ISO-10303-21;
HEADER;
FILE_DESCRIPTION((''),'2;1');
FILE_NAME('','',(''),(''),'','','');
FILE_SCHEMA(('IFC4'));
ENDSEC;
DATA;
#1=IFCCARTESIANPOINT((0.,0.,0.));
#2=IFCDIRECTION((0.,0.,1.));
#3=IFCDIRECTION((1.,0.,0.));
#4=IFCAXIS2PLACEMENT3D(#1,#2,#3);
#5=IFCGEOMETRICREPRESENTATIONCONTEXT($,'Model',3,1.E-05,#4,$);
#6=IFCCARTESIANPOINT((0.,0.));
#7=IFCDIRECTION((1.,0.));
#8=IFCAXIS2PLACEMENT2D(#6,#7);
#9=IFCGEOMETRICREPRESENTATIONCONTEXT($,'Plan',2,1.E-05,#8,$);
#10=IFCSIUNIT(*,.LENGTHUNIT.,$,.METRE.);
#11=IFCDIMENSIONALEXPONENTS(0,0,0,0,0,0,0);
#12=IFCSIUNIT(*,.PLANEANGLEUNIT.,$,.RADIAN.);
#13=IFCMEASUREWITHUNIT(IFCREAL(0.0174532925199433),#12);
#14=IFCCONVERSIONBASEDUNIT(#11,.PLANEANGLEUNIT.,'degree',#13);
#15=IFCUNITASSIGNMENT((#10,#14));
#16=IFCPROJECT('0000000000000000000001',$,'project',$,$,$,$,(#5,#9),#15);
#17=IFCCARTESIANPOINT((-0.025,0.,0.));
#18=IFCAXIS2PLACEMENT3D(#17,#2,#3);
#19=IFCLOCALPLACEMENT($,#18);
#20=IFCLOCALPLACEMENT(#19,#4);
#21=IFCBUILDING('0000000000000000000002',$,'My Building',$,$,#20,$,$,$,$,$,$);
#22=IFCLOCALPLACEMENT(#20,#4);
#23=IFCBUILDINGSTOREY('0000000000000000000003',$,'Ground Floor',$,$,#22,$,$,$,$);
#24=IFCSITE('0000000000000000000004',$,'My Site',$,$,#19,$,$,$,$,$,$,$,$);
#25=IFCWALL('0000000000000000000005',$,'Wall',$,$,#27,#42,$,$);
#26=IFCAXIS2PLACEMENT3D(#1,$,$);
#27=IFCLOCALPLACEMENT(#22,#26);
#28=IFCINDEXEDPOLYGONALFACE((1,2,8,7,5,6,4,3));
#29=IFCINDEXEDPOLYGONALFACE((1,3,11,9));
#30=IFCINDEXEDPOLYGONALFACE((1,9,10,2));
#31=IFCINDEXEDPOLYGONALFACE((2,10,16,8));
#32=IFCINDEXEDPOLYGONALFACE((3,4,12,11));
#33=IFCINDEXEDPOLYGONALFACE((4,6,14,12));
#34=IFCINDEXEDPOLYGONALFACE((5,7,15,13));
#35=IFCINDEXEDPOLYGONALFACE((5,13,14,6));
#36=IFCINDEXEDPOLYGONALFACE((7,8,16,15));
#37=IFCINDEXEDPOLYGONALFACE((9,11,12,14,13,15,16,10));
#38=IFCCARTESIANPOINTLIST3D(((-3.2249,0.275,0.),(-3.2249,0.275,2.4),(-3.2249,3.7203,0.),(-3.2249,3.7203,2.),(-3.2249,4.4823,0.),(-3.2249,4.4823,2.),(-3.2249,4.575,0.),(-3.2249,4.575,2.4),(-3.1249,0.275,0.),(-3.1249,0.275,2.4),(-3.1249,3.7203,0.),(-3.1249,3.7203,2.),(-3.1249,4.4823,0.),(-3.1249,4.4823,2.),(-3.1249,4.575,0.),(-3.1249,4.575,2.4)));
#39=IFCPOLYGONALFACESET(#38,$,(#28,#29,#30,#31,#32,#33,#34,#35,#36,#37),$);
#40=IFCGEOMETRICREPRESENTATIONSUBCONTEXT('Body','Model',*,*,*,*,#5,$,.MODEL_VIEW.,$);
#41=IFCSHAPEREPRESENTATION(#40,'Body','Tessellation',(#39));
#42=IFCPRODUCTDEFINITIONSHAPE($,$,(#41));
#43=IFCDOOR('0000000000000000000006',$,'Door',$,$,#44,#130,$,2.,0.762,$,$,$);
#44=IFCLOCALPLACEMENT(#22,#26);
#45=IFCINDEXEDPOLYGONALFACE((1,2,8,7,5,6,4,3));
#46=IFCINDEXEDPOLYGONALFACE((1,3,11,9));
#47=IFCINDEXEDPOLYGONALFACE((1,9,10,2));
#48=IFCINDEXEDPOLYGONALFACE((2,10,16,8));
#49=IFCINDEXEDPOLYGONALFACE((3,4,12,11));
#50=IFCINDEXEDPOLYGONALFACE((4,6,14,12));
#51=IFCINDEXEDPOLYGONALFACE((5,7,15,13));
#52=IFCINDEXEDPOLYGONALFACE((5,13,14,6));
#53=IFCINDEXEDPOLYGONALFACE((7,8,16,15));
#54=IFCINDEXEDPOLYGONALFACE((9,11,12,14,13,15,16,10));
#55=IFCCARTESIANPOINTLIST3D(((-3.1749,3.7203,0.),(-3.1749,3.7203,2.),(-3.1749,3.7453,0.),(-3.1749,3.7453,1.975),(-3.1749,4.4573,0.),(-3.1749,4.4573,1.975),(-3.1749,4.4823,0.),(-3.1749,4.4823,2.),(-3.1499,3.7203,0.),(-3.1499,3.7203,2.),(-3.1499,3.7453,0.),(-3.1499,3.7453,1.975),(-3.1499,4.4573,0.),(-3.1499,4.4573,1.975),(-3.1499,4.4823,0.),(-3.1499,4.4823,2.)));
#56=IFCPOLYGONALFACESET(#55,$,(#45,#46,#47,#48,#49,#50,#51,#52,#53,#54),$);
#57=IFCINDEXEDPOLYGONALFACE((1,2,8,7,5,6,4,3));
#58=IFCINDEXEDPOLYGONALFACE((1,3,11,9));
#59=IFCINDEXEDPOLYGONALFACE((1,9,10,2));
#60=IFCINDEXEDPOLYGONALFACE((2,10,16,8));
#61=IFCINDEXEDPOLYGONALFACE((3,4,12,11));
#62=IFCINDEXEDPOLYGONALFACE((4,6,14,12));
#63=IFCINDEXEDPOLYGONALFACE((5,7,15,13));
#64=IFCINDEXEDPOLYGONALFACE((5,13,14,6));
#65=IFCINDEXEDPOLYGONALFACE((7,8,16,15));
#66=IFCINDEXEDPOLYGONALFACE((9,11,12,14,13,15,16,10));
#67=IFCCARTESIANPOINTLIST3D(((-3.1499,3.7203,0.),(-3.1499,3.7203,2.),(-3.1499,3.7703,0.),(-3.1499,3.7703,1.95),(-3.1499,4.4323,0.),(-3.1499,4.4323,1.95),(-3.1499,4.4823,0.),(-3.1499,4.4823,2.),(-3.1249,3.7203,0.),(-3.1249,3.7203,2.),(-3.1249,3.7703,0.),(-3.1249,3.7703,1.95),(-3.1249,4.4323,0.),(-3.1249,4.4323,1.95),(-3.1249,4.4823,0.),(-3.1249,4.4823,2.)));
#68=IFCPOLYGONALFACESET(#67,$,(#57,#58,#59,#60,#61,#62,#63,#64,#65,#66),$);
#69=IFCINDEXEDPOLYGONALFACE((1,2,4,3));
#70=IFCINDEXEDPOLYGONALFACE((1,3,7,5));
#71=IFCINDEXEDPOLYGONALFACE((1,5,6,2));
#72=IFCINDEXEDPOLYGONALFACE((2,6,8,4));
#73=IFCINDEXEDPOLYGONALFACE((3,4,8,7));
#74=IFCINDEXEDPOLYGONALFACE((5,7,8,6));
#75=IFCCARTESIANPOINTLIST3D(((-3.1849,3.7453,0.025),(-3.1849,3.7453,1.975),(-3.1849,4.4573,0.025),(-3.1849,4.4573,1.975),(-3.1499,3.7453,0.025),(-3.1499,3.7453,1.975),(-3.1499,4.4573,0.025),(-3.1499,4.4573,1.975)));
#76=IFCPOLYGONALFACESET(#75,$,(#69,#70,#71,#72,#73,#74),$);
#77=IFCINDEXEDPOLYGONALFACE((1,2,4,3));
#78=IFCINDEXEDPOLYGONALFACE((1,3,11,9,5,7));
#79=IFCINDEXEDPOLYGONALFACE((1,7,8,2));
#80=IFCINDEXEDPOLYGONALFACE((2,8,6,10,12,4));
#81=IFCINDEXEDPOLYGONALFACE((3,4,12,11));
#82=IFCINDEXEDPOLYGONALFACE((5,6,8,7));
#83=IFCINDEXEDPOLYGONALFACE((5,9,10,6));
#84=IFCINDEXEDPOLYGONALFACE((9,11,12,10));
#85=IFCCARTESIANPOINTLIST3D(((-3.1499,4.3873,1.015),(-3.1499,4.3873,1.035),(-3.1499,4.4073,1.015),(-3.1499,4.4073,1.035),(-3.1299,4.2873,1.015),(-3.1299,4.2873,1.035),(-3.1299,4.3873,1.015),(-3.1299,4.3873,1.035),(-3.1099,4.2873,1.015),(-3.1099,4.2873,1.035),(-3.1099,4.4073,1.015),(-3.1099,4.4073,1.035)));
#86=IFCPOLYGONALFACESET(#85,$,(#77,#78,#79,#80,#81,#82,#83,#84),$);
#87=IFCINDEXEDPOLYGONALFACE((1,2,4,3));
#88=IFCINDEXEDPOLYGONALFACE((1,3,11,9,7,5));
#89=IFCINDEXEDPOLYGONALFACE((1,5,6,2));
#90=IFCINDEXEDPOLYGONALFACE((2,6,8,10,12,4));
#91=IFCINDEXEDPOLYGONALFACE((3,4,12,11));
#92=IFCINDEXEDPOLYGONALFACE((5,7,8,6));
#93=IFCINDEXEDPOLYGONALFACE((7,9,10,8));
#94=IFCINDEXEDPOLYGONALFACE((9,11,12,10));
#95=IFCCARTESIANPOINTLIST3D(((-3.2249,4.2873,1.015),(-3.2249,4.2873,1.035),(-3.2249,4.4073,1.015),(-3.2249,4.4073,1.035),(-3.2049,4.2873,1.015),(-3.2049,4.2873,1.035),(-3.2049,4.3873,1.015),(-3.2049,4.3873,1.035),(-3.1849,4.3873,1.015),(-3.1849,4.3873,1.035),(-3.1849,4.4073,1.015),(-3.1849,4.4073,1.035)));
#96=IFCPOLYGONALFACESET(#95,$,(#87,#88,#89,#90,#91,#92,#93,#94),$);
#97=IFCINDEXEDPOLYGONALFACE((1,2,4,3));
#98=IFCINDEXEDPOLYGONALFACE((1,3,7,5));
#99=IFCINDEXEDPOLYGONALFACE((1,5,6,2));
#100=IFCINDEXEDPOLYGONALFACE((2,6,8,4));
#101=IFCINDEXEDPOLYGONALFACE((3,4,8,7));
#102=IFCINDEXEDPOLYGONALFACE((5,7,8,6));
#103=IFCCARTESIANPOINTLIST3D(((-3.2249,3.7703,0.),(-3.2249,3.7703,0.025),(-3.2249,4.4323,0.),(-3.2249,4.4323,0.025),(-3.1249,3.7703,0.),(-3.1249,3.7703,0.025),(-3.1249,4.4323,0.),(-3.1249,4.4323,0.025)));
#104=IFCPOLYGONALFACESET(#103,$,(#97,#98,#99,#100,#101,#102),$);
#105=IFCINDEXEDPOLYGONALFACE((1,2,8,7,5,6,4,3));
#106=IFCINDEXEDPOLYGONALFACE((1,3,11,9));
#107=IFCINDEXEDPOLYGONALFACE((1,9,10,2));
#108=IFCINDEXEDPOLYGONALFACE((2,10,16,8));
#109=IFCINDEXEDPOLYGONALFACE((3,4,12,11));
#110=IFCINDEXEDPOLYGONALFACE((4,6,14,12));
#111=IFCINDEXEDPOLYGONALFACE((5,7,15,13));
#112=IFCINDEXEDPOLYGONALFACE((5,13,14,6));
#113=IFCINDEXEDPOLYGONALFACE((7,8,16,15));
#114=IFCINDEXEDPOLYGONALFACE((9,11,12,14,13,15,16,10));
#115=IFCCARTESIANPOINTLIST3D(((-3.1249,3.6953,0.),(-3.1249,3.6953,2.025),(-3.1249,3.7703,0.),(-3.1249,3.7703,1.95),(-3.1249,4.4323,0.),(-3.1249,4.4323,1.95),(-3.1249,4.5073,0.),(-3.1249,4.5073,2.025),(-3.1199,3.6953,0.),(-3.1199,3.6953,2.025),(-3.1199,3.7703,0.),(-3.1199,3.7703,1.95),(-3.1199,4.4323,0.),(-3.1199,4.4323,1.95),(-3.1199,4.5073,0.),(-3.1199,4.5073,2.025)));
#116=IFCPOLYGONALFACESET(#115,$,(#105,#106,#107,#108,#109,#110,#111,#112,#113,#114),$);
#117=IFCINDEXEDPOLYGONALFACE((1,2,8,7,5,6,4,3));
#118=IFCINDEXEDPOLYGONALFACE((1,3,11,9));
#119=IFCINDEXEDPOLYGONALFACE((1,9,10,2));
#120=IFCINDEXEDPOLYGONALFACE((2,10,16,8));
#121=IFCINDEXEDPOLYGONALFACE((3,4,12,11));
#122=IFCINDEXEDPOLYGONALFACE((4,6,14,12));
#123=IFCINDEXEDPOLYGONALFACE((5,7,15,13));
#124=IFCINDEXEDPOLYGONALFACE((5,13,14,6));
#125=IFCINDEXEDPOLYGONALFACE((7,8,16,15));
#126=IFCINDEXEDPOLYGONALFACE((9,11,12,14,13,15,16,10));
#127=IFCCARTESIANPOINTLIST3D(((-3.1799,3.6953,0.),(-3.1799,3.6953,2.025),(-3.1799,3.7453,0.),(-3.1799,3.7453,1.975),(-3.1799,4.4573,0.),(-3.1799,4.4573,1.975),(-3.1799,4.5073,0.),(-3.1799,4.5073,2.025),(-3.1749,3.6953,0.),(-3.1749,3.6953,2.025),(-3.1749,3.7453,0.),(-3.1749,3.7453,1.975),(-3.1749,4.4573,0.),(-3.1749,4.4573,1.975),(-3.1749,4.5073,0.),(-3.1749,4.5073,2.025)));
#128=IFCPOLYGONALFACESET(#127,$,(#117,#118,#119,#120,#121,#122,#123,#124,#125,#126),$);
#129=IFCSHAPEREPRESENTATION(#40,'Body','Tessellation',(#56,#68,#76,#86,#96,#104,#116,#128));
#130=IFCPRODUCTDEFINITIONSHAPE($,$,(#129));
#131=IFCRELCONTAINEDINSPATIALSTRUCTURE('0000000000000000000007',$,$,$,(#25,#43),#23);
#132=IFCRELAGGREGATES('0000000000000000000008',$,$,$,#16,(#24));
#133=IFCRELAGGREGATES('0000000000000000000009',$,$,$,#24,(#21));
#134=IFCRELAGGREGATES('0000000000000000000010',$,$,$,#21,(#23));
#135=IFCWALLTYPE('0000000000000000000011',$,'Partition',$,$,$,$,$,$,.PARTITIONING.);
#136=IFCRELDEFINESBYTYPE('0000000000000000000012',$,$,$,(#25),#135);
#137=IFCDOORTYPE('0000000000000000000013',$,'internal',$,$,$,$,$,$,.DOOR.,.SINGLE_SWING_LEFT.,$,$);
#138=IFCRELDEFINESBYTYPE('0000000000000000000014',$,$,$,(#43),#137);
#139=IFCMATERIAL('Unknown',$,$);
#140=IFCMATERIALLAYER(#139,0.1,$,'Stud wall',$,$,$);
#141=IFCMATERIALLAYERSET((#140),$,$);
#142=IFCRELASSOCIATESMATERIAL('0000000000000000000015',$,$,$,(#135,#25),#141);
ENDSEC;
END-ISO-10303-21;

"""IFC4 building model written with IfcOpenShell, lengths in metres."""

from ifc_helpers import new_model, entity, si_unit, converted_unit, frame, origin_with_axes, origin_2d_with_axis, place, context, subcontext, project, spatial, line, indexed_curve, outline, extrude, shape, source, transform, mapped, material, layer, layer_set, layer_usage, type_object, type_shapes, element, fill, save


model = new_model("IFC4")

# Units and contexts
model_context = context("Model", 3, precision=1e-05, world=origin_with_axes())
plan_context = context("Plan", 2, precision=1e-05, world=origin_2d_with_axis())
body_context_1 = subcontext(model_context, "Body", "Model", "MODEL_VIEW")
body_context_2 = subcontext(plan_context, "Body", "Plan", "PLAN_VIEW")
ifc_project = project(units=[si_unit("LENGTHUNIT", "METRE"), converted_unit("PLANEANGLEUNIT", "degree", entity("IfcReal", 0.0174532925199433), si_unit("PLANEANGLEUNIT", "RADIAN"), dimensions=[0, 0, 0, 0, 0, 0, 0])], contexts=[model_context, plan_context])

# Site, building, storey
site_placement = place(None, frame((-0.025, 0.0, 0.0), z_axis=(0.0, 0.0, 1.0), x_axis=(1.0, 0.0, 0.0)))
site = spatial("IfcSite", under=ifc_project, at=site_placement, Name="My Site")
building_placement = place(site_placement, origin_with_axes())
building = spatial("IfcBuilding", under=site, at=building_placement, Name="My Building")
storey_placement = place(building_placement, frame((0.0, 0.0, 0.0), z_axis=(0.0, 0.0, 1.0), x_axis=(1.0, 0.0, 0.0)))
storey = spatial("IfcBuildingStorey", under=building, at=storey_placement, Name="Ground Floor")

# Shared definitions
ifc_material = material(Name="Unknown")
shared_shape_1 = source(origin_with_axes(), body_context_1, "Body", "SweptSolid", [
    extrude(outline(indexed_curve([(0.0, 0.0), (0.762, 0.0), (0.762, 2.0), (0.0, 2.0)], segments=[line(1, 2, 3, 4, 1)])), frame((0.0, -0.6, 0.0), z_axis=(0.0, -1.0, 0.0), x_axis=(1.0, 0.0, 0.0)), (0.0, 0.0, -1.0), 1.2),
])
door_type = type_object("IfcDoorType", Name="internal", OperationType="SINGLE_SWING_LEFT", PredefinedType="DOOR")
shared_shape_2 = source(origin_with_axes(), body_context_1, "Body", "SweptSolid", [
    extrude(outline(indexed_curve([(0.0, 0.0), (0.0, 2.0), (0.762, 2.0), (0.762, 0.0), (0.737, 0.0), (0.737, 1.975), (0.025, 1.975), (0.025, 0.0)], segments=[line(1, 2, 3, 4, 5, 6, 7, 8, 1)])), frame((0.0, 0.025, 0.0), z_axis=(0.0, -1.0, 0.0), x_axis=(1.0, 0.0, 0.0)), (0.0, 0.0, -1.0), 0.025),
    extrude(outline(indexed_curve([(0.0, 0.0), (0.0, 2.0), (0.762, 2.0), (0.762, 0.0), (0.712, 0.0), (0.712, 1.95), (0.05, 1.95), (0.05, 0.0)], segments=[line(1, 2, 3, 4, 5, 6, 7, 8, 1)])), frame((0.0, 0.0, 0.0), z_axis=(0.0, -1.0, 0.0), x_axis=(1.0, 0.0, 0.0)), (0.0, 0.0, -1.0), 0.025),
    extrude(outline(indexed_curve([(0.0, 0.0), (0.712, 0.0), (0.712, 0.035), (0.0, 0.035)], segments=[line(1, 2, 3, 4, 1)])), frame((0.025, 0.025, 0.025), z_axis=(0.0, 0.0, 1.0), x_axis=(1.0, 0.0, 0.0)), (0.0, 0.0, 1.0), 1.95),
    extrude(outline(indexed_curve([(0.0, 0.0), (0.0, -0.04), (-0.12, -0.04), (-0.12, -0.02), (-0.02, -0.02), (-0.02, 0.0)], segments=[line(1, 2, 3, 4, 5, 6, 1)])), frame((0.687, 0.025, 1.015), z_axis=(0.0, 0.0, 1.0), x_axis=(1.0, 0.0, 0.0)), (0.0, 0.0, 1.0), 0.02),
    extrude(outline(indexed_curve([(0.0, 0.0), (0.0, 0.04), (-0.12, 0.04), (-0.12, 0.02), (-0.02, 0.02), (-0.02, 0.0)], segments=[line(1, 2, 3, 4, 5, 6, 1)])), frame((0.687, 0.06, 1.015), z_axis=(0.0, 0.0, 1.0), x_axis=(1.0, 0.0, 0.0)), (0.0, 0.0, 1.0), 0.02),
    extrude(outline(indexed_curve([(0.0, 0.0), (0.662, 0.0), (0.662, 0.1), (0.0, 0.1)], segments=[line(1, 2, 3, 4, 1)])), frame((0.05, 0.0, 0.0), z_axis=(0.0, 0.0, 1.0), x_axis=(1.0, 0.0, 0.0)), (0.0, 0.0, 1.0), 0.025),
    extrude(outline(indexed_curve([(0.0, 0.0), (0.0, 2.025), (0.812, 2.025), (0.812, 0.0), (0.737, 0.0), (0.737, 1.95), (0.075, 1.95), (0.075, 0.0)], segments=[line(1, 2, 3, 4, 5, 6, 7, 8, 1)])), frame((-0.025, -0.005, 0.0), z_axis=(0.0, -1.0, 0.0), x_axis=(1.0, 0.0, 0.0)), (0.0, 0.0, -1.0), 0.005),
    extrude(outline(indexed_curve([(0.0, 0.0), (0.0, 2.025), (0.812, 2.025), (0.812, 0.0), (0.762, 0.0), (0.762, 1.975), (0.05, 1.975), (0.05, 0.0)], segments=[line(1, 2, 3, 4, 5, 6, 7, 8, 1)])), frame((-0.025, 0.05, 0.0), z_axis=(0.0, -1.0, 0.0), x_axis=(1.0, 0.0, 0.0)), (0.0, 0.0, -1.0), 0.005),
])
shared_shape_3 = source(origin_with_axes(), body_context_2, "Body", "Curve2D", [
    entity("IfcIndexedPolyCurve", entity("IfcCartesianPointList2D", [[0.0, 0.0], [0.0, 0.05], [0.025, 0.05], [0.025, 0.025], [0.05, 0.025], [0.05, 0.0]]), [entity("IfcLineIndex", [1, 2, 3, 4, 5, 6, 1])]),
    entity("IfcIndexedPolyCurve", entity("IfcCartesianPointList2D", [[0.762, 0.0], [0.762, 0.05], [0.737, 0.05], [0.737, 0.025], [0.712, 0.025], [0.712, 0.0]]), [entity("IfcLineIndex", [1, 2, 3, 4, 5, 6, 1])]),
    entity("IfcTrimmedCurve", entity("IfcEllipse", entity("IfcAxis2Placement2D", entity("IfcCartesianPoint", [0.06, 0.05]), entity("IfcDirection", [1.0, 0.0])), 0.677, 0.712), [entity("IfcCartesianPoint", [0.737, 0.05])], [entity("IfcCartesianPoint", [0.06, 0.762])], True, "CARTESIAN"),
    entity("IfcIndexedPolyCurve", entity("IfcCartesianPointList2D", [[0.025, 0.05], [0.06, 0.05], [0.06, 0.762], [0.025, 0.762]]), [entity("IfcLineIndex", [1, 2, 3, 4, 1])]),
])
type_shapes(door_type, [shared_shape_2, shared_shape_3])

# Wall, opening, door
ifc_layer_1 = layer(ifc_material, 0.1, Name="Stud wall")
ifc_layer_set_1 = layer_set([ifc_layer_1])
ifc_layer_usage_1 = layer_usage(ifc_layer_set_1, "AXIS2", "POSITIVE", 0.0)
wall_type_1 = type_object("IfcWallType", Name="Partition", PredefinedType="PARTITIONING", material=ifc_layer_set_1)
wall_1_placement = place(storey_placement, frame((-3.1249, 0.275, 0.0), z_axis=(0.0, 0.0, 1.0), x_axis=(0.0, 1.0, 0.0)))
wall_1 = element("IfcWall", 1, at=wall_1_placement, inside=storey, type_object=wall_type_1, material=ifc_layer_usage_1, Name="Wall", context=body_context_1, shape_type="SweptSolid", body=[
    extrude(outline(indexed_curve([(0.0, 0.0), (0.0, 0.1), (4.3, 0.1), (4.3, 0.0), (0.0, 0.0)], self_intersect=False)), origin_with_axes(), (0.0, 0.0, 1.0), 2.4),
])
opening_1_placement = place(wall_1_placement, frame((3.4453, 0.0, 0.0), z_axis=(0.0, 0.0, 1.0), x_axis=(1.0, 0.0, 0.0)))
opening_1 = element("IfcOpeningElement", 2, at=opening_1_placement, cuts=wall_1, PredefinedType="OPENING", context=body_context_1, shape_type="MappedRepresentation", body=[
    mapped(shared_shape_1, transform((0.0, 0.0, 0.0), x_axis=(1.0, 0.0, 0.0), y_axis=(0.0, 1.0, 0.0), z_axis=(0.0, 0.0, 1.0), scale=1.0)),
])
door_1_placement = place(opening_1_placement, frame((0.0, 0.0, 0.0), z_axis=(0.0, 0.0, 1.0), x_axis=(1.0, 0.0, 0.0)))
door_1 = element("IfcDoor", 3, at=door_1_placement, inside=storey, type_object=door_type, Name="Door", OverallHeight=2.0, OverallWidth=0.762, shapes=[
    shape(body_context_1, "Body", "MappedRepresentation", [mapped(shared_shape_2, transform((0.0, 0.0, 0.0), x_axis=(1.0, 0.0, 0.0), y_axis=(0.0, 1.0, 0.0), z_axis=(0.0, 0.0, 1.0), scale=1.0))]),
    shape(body_context_2, "Body", "MappedRepresentation", [mapped(shared_shape_3, transform((0.0, 0.0, 0.0), x_axis=(1.0, 0.0, 0.0), y_axis=(0.0, 1.0, 0.0), z_axis=(0.0, 0.0, 1.0), scale=1.0))]),
])
fill(opening_1, door_1)

save(model, "model.ifc")
